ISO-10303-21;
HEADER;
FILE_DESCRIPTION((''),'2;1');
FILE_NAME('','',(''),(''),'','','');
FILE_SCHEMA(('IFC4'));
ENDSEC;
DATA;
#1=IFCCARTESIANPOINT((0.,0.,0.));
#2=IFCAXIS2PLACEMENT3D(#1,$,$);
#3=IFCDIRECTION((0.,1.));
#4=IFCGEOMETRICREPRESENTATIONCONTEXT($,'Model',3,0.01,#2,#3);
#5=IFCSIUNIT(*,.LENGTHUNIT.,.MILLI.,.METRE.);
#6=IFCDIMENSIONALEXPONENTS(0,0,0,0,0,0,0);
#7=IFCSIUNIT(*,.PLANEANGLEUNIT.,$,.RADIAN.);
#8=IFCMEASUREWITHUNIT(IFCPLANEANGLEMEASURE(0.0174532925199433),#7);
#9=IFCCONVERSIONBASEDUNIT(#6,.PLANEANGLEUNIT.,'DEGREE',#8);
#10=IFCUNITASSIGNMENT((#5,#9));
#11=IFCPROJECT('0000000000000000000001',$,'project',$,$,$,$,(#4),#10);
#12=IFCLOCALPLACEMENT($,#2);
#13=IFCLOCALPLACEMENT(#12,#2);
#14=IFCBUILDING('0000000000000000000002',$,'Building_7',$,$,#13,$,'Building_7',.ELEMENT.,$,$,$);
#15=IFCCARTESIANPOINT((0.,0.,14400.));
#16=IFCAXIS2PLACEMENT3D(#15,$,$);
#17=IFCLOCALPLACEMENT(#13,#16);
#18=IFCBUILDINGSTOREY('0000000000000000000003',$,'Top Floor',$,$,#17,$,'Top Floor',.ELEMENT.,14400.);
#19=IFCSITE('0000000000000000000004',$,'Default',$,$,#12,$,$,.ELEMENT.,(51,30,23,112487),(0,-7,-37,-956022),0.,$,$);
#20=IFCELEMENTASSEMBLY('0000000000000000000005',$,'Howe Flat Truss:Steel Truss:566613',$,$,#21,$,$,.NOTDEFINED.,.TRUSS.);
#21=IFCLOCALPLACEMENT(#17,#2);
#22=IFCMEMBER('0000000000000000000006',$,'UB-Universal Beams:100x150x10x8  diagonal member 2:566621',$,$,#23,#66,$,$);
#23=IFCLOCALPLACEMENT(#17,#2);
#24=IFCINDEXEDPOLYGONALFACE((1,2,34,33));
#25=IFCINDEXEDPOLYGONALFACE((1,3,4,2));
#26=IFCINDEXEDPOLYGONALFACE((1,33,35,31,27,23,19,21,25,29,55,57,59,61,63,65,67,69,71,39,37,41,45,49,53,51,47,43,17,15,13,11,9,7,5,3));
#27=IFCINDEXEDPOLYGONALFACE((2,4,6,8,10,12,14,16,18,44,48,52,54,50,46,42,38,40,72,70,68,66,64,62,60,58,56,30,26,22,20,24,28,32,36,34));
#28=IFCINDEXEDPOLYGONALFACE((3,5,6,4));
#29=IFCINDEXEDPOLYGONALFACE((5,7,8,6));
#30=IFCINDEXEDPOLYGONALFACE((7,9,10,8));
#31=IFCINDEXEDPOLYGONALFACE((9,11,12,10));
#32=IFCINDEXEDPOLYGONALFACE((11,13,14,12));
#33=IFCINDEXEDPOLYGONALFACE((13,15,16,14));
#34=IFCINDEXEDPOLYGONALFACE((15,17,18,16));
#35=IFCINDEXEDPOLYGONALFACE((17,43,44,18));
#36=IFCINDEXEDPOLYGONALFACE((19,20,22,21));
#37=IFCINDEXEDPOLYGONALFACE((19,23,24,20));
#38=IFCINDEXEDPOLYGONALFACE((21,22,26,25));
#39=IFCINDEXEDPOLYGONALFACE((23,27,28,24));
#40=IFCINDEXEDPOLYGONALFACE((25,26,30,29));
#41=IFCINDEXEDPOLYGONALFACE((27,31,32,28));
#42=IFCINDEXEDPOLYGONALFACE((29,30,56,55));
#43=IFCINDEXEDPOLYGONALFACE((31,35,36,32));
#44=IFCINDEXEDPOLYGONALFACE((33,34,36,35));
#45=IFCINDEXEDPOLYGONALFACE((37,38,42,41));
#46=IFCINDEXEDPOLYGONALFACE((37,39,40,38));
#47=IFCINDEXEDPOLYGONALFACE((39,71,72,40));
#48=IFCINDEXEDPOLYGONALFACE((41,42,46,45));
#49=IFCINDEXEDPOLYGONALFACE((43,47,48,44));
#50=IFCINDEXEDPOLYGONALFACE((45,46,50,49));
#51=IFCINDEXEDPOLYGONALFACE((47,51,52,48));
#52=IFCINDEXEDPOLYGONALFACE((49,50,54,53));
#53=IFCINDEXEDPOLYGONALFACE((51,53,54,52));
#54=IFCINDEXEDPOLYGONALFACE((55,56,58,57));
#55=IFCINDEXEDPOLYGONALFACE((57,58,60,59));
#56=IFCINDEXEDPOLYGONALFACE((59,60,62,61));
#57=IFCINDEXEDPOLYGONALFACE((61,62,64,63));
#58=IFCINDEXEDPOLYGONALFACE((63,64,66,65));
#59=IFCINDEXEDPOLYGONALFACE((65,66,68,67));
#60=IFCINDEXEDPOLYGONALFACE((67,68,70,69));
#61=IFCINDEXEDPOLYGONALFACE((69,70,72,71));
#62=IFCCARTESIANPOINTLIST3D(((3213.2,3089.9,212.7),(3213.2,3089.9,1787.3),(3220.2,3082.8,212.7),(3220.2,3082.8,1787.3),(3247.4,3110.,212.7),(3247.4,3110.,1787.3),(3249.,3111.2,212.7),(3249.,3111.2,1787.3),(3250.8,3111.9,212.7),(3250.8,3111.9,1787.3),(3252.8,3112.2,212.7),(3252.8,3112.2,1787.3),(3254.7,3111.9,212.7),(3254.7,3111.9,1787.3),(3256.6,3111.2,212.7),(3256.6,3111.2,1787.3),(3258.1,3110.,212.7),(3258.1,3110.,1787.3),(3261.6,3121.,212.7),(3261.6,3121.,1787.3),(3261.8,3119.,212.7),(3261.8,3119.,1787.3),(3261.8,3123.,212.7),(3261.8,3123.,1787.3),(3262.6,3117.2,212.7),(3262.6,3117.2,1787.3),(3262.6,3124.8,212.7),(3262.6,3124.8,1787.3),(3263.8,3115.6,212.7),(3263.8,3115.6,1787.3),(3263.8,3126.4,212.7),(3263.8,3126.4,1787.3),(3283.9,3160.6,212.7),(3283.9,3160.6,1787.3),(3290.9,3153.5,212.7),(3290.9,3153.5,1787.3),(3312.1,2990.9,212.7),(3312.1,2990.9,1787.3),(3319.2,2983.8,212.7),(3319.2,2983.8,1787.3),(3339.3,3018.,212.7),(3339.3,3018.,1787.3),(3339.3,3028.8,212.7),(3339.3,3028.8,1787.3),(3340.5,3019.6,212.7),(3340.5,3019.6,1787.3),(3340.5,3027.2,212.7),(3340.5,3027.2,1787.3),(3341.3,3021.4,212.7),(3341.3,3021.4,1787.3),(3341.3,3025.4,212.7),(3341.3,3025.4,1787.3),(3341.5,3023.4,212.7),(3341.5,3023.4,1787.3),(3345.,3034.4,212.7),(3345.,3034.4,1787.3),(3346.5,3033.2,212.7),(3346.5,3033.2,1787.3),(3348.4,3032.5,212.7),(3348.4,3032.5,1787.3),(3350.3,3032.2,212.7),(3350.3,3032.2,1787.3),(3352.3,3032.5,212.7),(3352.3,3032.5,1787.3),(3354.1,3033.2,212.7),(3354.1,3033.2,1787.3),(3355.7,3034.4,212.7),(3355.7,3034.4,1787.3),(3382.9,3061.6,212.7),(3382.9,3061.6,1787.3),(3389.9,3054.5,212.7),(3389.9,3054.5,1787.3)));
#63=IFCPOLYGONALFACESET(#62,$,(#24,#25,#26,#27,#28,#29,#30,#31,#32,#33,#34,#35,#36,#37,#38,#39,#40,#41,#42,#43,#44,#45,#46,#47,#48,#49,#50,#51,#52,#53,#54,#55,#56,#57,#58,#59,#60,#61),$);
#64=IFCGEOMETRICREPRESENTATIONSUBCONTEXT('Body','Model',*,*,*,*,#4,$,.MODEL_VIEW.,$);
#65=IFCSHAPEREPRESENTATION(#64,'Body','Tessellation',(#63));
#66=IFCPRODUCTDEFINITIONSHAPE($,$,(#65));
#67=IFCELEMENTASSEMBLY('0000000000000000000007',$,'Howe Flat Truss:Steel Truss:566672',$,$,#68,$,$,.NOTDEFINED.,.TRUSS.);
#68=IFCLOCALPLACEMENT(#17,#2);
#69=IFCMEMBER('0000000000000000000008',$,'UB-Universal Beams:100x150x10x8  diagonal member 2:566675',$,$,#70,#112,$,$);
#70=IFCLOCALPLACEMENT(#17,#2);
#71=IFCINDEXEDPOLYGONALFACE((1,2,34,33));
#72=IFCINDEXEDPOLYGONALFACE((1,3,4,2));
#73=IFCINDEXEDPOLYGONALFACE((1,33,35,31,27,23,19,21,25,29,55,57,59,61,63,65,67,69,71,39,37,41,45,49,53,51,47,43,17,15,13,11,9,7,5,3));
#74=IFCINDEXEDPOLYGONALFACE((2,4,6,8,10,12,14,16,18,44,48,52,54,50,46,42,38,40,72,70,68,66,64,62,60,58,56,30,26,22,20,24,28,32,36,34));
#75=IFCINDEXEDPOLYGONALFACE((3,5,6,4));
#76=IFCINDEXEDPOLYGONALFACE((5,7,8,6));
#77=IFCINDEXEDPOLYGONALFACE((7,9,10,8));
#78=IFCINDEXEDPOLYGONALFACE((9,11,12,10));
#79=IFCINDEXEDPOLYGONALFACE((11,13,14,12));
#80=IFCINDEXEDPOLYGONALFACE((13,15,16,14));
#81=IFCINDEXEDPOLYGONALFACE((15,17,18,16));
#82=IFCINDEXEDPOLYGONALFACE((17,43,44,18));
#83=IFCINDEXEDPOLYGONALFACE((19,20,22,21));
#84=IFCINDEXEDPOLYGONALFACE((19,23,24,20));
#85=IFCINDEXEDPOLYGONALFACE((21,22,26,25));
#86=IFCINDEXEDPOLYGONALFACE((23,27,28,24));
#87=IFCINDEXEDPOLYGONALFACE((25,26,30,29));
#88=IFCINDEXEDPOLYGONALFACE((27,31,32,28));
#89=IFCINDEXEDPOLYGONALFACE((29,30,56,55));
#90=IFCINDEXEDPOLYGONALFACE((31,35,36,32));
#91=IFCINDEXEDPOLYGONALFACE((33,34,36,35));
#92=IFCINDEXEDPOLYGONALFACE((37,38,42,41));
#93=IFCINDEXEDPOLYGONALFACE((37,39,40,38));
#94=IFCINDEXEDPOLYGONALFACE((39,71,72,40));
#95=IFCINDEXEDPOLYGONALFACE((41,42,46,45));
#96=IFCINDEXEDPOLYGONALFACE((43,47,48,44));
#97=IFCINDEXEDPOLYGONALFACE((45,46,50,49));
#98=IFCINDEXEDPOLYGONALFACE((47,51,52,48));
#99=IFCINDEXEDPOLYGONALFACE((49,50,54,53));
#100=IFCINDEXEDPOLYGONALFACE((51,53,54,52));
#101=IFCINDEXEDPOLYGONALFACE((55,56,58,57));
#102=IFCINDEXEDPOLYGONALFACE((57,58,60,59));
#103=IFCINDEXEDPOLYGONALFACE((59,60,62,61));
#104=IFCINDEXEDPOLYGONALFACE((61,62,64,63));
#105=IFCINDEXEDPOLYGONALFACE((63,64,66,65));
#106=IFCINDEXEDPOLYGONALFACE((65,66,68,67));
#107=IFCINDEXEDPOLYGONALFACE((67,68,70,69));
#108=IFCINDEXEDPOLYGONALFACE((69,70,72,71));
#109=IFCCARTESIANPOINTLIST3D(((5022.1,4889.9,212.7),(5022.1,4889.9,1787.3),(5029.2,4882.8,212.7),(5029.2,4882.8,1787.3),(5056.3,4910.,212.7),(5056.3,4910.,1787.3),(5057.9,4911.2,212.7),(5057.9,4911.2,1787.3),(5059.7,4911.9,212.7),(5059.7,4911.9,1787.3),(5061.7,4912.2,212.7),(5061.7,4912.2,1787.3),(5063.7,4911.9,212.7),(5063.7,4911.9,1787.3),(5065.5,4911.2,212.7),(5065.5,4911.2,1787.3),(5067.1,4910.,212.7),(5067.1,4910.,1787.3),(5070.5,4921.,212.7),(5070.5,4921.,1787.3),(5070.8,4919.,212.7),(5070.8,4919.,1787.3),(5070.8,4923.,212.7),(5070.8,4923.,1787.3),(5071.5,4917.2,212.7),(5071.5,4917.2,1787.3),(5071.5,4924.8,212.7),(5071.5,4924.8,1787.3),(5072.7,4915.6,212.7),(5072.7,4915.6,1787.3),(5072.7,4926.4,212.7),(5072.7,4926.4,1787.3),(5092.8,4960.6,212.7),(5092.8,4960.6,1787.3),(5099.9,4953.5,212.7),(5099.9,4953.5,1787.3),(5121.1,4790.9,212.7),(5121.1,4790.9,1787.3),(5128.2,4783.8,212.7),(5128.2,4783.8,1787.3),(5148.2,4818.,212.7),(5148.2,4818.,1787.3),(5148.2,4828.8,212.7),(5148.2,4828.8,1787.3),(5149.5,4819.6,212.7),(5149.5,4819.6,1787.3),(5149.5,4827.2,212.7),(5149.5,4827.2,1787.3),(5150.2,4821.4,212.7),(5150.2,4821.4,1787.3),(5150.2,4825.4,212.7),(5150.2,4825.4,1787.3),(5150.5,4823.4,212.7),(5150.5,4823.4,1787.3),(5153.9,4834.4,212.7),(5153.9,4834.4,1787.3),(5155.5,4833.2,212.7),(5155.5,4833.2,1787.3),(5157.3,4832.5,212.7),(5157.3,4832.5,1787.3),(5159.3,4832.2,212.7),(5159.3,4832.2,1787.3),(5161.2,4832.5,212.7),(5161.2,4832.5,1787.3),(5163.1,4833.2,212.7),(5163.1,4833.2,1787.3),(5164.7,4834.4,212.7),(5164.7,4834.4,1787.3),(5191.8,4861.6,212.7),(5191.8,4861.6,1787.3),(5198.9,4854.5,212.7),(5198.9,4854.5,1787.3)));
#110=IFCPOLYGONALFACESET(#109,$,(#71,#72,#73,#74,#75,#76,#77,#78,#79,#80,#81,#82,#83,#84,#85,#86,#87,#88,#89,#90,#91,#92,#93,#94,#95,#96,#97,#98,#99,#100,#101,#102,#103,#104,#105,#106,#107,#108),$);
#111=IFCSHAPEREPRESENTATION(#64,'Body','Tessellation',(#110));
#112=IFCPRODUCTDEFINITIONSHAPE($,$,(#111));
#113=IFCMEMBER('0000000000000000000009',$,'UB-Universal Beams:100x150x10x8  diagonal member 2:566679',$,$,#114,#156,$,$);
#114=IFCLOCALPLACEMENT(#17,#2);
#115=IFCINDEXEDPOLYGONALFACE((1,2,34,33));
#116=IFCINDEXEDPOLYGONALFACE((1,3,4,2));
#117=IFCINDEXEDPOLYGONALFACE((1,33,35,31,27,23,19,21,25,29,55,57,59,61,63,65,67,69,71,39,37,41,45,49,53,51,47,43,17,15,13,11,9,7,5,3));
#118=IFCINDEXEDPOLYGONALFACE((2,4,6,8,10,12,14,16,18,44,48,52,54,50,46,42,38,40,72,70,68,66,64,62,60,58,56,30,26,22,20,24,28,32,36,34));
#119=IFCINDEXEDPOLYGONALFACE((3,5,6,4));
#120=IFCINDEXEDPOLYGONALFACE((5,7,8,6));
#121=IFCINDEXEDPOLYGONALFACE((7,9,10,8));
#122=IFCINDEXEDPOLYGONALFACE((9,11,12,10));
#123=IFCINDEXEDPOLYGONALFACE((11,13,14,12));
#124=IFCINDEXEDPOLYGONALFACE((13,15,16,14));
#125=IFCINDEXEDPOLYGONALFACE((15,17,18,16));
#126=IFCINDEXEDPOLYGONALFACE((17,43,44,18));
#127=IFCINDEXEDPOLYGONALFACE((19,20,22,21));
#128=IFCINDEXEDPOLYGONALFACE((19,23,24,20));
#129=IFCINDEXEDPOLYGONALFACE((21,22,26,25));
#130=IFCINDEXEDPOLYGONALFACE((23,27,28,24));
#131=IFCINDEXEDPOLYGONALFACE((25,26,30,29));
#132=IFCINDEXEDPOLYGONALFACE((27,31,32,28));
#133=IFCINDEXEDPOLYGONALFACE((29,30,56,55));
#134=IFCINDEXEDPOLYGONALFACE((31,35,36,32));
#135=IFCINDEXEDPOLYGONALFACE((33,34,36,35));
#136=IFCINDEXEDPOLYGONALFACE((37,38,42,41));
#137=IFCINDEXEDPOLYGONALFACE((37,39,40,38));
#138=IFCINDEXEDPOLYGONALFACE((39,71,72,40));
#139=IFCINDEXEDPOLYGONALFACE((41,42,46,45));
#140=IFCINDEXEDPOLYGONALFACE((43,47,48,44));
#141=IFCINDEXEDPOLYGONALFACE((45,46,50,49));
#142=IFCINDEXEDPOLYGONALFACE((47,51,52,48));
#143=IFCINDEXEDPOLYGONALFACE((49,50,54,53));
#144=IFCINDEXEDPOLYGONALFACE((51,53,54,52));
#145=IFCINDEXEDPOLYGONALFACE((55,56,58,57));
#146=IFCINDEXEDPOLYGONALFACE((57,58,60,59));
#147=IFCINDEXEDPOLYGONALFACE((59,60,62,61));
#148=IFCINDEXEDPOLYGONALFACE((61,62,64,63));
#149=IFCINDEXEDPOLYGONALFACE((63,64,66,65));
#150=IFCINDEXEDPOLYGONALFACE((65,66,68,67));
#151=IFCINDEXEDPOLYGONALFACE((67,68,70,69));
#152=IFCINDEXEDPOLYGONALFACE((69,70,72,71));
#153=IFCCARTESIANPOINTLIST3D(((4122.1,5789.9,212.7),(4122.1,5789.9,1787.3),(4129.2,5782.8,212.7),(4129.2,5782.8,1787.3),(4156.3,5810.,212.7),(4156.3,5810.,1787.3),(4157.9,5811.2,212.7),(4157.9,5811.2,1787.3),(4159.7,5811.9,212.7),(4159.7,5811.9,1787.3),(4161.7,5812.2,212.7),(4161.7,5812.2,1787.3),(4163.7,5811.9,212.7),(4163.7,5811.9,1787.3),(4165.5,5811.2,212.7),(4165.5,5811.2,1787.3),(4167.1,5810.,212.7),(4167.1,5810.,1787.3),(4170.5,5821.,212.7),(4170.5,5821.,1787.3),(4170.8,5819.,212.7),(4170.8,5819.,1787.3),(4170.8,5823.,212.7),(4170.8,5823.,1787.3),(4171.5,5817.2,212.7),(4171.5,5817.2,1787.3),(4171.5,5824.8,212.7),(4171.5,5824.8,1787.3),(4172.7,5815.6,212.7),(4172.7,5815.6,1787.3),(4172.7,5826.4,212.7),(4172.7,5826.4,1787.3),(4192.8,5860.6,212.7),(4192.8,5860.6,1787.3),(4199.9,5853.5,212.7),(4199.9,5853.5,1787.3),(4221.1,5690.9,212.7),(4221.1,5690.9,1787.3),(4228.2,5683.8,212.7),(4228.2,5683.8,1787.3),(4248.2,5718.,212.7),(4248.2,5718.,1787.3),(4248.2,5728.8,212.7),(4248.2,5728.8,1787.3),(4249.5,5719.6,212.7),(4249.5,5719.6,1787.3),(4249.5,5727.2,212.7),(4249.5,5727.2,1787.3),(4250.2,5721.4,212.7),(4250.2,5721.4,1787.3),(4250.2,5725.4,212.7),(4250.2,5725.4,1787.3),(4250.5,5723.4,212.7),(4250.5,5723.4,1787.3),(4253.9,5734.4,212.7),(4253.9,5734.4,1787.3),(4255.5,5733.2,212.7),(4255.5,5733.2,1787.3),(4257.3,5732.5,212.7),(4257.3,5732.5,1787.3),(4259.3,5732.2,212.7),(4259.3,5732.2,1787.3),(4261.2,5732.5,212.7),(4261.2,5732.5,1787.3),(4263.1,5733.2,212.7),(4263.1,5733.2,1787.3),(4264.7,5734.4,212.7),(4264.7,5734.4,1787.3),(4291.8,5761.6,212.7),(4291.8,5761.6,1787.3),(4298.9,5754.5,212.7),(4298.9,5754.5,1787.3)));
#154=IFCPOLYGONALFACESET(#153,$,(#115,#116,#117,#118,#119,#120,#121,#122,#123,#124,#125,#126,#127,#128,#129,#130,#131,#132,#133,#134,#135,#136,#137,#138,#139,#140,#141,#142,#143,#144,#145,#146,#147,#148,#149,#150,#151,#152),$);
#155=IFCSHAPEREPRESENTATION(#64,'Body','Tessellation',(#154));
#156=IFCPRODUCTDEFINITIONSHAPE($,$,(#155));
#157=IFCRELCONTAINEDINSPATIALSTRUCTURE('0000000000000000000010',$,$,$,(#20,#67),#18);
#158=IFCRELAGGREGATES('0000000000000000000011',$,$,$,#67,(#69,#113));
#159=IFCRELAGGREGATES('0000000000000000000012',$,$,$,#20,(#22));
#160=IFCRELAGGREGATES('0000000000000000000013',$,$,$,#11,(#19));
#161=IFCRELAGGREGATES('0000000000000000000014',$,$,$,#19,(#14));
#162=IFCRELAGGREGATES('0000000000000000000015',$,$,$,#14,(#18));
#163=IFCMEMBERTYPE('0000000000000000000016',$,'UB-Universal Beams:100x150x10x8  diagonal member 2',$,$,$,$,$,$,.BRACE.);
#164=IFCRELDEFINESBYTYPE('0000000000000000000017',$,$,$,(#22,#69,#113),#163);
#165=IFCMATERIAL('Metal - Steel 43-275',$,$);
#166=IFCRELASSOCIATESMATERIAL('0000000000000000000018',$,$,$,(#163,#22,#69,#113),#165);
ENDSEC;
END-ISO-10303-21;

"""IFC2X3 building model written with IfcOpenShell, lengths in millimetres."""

from ifc_helpers import new_model, entity, si_unit, converted_unit, direction, frame, frame_2d, origin, place, context, subcontext, project, spatial, polyline, circle_curve, parameter, trimmed, segment, composite_curve, outline, extrude, source, transform, mapped, material, type_object, type_shapes, element, aggregate, save


model = new_model("IFC2X3")

# Units and contexts
model_context = context("Model", 3, precision=0.01, world=origin(), true_north=direction((0.0, 1.0)))
body_context = subcontext(model_context, "Body", "Model", "MODEL_VIEW")
ifc_project = project(units=[si_unit("LENGTHUNIT", "METRE", prefix="MILLI"), converted_unit("PLANEANGLEUNIT", "DEGREE", entity("IfcPlaneAngleMeasure", 0.0174532925199433), si_unit("PLANEANGLEUNIT", "RADIAN"), dimensions=[0, 0, 0, 0, 0, 0, 0])], contexts=[model_context])

# Site, building, storey
site_placement = place(None, origin())
site = spatial("IfcSite", under=ifc_project, at=site_placement, Name="Default", CompositionType="ELEMENT", RefLatitude=(51, 30, 23, 112487), RefLongitude=(0, -7, -37, -956022), RefElevation=0.0)
building_placement = place(site_placement, origin())
building = spatial("IfcBuilding", under=site, at=building_placement, Name="Building_7", LongName="Building_7", CompositionType="ELEMENT")
storey_placement = place(building_placement, frame((0.0, 0.0, 14400.0)))
storey = spatial("IfcBuildingStorey", under=building, at=storey_placement, Name="Top Floor", LongName="Top Floor", CompositionType="ELEMENT", Elevation=14400.0)

# Shared definitions
ifc_material = material(Name="Metal - Steel 43-275")

# Element assemblies, members
assembly_1_placement = place(storey_placement, origin())
assembly_1 = element("IfcElementAssembly", 1, at=assembly_1_placement, inside=storey, Name="Howe Flat Truss:Steel Truss:566613", AssemblyPlace="NOTDEFINED", PredefinedType="TRUSS")
member_type_1 = type_object("IfcMemberType", Name="UB-Universal Beams:100x150x10x8  diagonal member 2", PredefinedType="BRACE", material=ifc_material)
shared_shape_1 = source(origin(), body_context, "Body", "SweptSolid", [
    extrude(outline(composite_curve([segment(polyline([(-50.0, -65.0), (-50.0, -75.0)]), True, "CONTINUOUS"), segment(polyline([(-50.0, -75.0), (50.0, -75.0)]), True, "CONTINUOUS"), segment(polyline([(50.0, -75.0), (50.0, -65.0)]), True, "CONTINUOUS"), segment(polyline([(50.0, -65.0), (11.6, -65.0)]), True, "CONTINUOUS"), segment(trimmed(circle_curve(frame_2d((11.6, -57.4), x_axis=(1.0, 0.0)), 7.6), [parameter(180.0)], [parameter(270.0)], True, "PARAMETER"), False, "CONTINUOUS"), segment(polyline([(4.0, -57.4), (4.0, 57.4)]), True, "CONTINUOUS"), segment(trimmed(circle_curve(frame_2d((11.6, 57.4), x_axis=(1.0, 0.0)), 7.6), [parameter(90.0)], [parameter(180.0)], True, "PARAMETER"), False, "CONTINUOUS"), segment(polyline([(11.6, 65.0), (50.0, 65.0)]), True, "CONTINUOUS"), segment(polyline([(50.0, 65.0), (50.0, 75.0)]), True, "CONTINUOUS"), segment(polyline([(50.0, 75.0), (-50.0, 75.0)]), True, "CONTINUOUS"), segment(polyline([(-50.0, 75.0), (-50.0, 65.0)]), True, "CONTINUOUS"), segment(polyline([(-50.0, 65.0), (-11.6, 65.0)]), True, "CONTINUOUS"), segment(trimmed(circle_curve(frame_2d((-11.6, 57.4), x_axis=(1.0, 0.0)), 7.6), [parameter(360.0)], [parameter(90.0)], True, "PARAMETER"), False, "CONTINUOUS"), segment(polyline([(-4.0, 57.4), (-4.0, -57.4)]), True, "CONTINUOUS"), segment(trimmed(circle_curve(frame_2d((-11.6, -57.4), x_axis=(1.0, 0.0)), 7.6), [parameter(270.0)], [parameter(360.0)], True, "PARAMETER"), False, "CONTINUOUS"), segment(polyline([(-11.6, -65.0), (-50.0, -65.0)]), True, "CONTINUOUS")], self_intersect=False)), frame((-787.3, 0.0, 0.0), z_axis=(-1.0, 0.0, 0.0), x_axis=(0.0, -1.0, 0.0)), (0.0, 0.0, -1.0), 1574.6),
])
type_shapes(member_type_1, [shared_shape_1])
member_1_placement = place(assembly_1_placement, frame((3301.5, 3072.2, 1000.0), z_axis=(0.707107, -0.707107, 0.0), x_axis=(0.0, 0.0, 1.0)))
member_1 = element("IfcMember", 2, at=member_1_placement, type_object=member_type_1, material=ifc_material, Name="UB-Universal Beams:100x150x10x8  diagonal member 2:566621", context=body_context, shape_type="MappedRepresentation", body=[
    mapped(shared_shape_1, transform((0.0, 0.0, 0.0), scale=1.0)),
])
assembly_2_placement = place(storey_placement, origin())
assembly_2 = element("IfcElementAssembly", 3, at=assembly_2_placement, inside=storey, Name="Howe Flat Truss:Steel Truss:566672", AssemblyPlace="NOTDEFINED", PredefinedType="TRUSS")
member_2_placement = place(assembly_2_placement, frame((5110.5, 4872.2, 1000.0), z_axis=(-0.707107, 0.707107, 0.0), x_axis=(0.0, 0.0, 1.0)))
member_2 = element("IfcMember", 4, at=member_2_placement, type_object=member_type_1, material=ifc_material, Name="UB-Universal Beams:100x150x10x8  diagonal member 2:566675", context=body_context, shape_type="MappedRepresentation", body=[
    mapped(shared_shape_1, transform((0.0, 0.0, 0.0), scale=1.0)),
])
member_3_placement = place(assembly_2_placement, frame((4210.5, 5772.2, 1000.0), z_axis=(-0.707107, 0.707107, 0.0), x_axis=(0.0, 0.0, 1.0)))
member_3 = element("IfcMember", 5, at=member_3_placement, type_object=member_type_1, material=ifc_material, Name="UB-Universal Beams:100x150x10x8  diagonal member 2:566679", context=body_context, shape_type="MappedRepresentation", body=[
    mapped(shared_shape_1, transform((0.0, 0.0, 0.0), scale=1.0)),
])

aggregate(assembly_2, [member_2, member_3])
aggregate(assembly_1, [member_1])

save(model, "model.ifc")
